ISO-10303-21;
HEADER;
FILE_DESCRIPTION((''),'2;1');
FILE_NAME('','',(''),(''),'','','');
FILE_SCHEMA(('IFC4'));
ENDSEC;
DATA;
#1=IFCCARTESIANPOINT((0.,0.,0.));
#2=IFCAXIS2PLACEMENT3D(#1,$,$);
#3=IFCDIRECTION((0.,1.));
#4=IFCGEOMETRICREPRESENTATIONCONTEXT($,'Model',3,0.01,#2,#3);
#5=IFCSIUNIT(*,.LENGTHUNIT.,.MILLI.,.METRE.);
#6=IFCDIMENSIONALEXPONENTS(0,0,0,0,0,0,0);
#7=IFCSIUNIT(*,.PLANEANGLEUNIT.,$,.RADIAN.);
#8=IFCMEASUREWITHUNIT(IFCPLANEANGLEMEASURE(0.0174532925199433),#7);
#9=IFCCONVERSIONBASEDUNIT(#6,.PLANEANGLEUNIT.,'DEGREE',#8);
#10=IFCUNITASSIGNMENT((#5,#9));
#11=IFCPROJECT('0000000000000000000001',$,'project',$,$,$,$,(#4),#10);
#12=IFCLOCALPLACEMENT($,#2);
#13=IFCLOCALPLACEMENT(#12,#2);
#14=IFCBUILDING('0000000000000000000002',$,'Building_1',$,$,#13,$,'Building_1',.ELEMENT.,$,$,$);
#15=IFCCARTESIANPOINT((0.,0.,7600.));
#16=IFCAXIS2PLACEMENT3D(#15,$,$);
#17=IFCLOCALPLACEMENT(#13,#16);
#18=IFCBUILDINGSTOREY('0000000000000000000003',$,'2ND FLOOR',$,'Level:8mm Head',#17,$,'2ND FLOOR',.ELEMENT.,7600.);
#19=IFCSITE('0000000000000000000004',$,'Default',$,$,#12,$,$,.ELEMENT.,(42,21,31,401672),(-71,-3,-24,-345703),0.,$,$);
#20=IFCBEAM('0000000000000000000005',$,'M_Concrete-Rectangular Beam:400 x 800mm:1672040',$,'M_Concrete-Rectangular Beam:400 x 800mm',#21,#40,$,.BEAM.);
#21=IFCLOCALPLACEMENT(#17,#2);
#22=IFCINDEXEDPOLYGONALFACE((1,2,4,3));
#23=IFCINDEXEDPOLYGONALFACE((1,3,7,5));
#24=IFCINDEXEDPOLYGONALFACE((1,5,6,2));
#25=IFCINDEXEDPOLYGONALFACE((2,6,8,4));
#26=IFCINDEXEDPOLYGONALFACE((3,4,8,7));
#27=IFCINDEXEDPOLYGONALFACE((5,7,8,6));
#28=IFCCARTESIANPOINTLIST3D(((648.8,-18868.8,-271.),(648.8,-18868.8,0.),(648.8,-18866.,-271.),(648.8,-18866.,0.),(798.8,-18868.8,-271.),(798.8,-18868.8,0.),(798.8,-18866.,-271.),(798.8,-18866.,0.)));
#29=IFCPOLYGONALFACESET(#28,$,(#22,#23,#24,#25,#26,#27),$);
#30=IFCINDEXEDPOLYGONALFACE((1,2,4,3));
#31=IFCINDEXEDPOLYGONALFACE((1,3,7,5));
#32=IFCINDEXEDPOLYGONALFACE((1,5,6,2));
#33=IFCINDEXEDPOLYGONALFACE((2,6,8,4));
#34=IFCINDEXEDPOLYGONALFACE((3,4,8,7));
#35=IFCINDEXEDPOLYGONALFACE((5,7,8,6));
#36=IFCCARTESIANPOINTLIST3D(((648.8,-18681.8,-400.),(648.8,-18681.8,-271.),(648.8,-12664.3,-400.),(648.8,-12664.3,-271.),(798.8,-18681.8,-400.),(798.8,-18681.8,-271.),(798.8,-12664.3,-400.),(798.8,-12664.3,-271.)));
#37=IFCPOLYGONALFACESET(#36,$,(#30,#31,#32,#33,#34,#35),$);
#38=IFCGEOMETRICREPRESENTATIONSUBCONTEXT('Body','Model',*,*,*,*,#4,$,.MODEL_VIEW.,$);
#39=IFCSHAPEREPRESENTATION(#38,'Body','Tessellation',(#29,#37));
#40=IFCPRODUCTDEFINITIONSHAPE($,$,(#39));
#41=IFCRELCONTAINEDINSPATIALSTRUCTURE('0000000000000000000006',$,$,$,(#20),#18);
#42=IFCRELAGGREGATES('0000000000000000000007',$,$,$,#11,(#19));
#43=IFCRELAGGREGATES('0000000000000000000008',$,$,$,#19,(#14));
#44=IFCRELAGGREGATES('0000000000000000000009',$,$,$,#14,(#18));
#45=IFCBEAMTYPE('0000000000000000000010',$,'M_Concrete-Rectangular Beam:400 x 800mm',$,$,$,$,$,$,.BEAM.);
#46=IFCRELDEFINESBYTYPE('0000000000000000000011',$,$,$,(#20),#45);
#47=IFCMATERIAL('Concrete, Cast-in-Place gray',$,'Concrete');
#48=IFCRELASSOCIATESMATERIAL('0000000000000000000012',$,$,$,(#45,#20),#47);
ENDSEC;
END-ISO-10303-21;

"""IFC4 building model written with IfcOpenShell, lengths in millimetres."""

from ifc_helpers import new_model, entity, si_unit, converted_unit, direction, frame, origin, place, context, subcontext, project, spatial, indexed_curve, outline, extrude, source, transform, mapped, material, type_object, type_shapes, element, save


model = new_model("IFC4")

# Units and contexts
model_context = context("Model", 3, precision=0.01, world=origin(), true_north=direction((0.0, 1.0)))
body_context = subcontext(model_context, "Body", "Model", "MODEL_VIEW")
ifc_project = project(units=[si_unit("LENGTHUNIT", "METRE", prefix="MILLI"), converted_unit("PLANEANGLEUNIT", "DEGREE", entity("IfcPlaneAngleMeasure", 0.0174532925199433), si_unit("PLANEANGLEUNIT", "RADIAN"), dimensions=[0, 0, 0, 0, 0, 0, 0])], contexts=[model_context])

# Site, building, storey
site_placement = place(None, origin())
site = spatial("IfcSite", under=ifc_project, at=site_placement, Name="Default", CompositionType="ELEMENT", RefLatitude=(42, 21, 31, 401672), RefLongitude=(-71, -3, -24, -345703), RefElevation=0.0)
building_placement = place(site_placement, origin())
building = spatial("IfcBuilding", under=site, at=building_placement, Name="Building_1", LongName="Building_1", CompositionType="ELEMENT")
storey_placement = place(building_placement, frame((0.0, 0.0, 7600.0)))
storey = spatial("IfcBuildingStorey", under=building, at=storey_placement, Name="2ND FLOOR", ObjectType="Level:8mm Head", LongName="2ND FLOOR", CompositionType="ELEMENT", Elevation=7600.0)

# Shared definitions
ifc_material_1 = material(Name="Concrete, Cast-in-Place gray", Category="Concrete")

# Beam
beam_type_1 = type_object("IfcBeamType", Name="M_Concrete-Rectangular Beam:400 x 800mm", PredefinedType="BEAM", material=ifc_material_1)
shared_shape_1 = source(origin(), body_context, "Body", "SweptSolid", [
    extrude(outline(indexed_curve([(-75.0, -135.5), (75.0, -135.5), (75.0, 135.5), (-75.0, 135.5), (-75.0, -135.5)], self_intersect=False)), frame((723.8, -18866.0, 7464.5), z_axis=(0.0, -1.0, 0.0), x_axis=(-1.0, 0.0, 0.0)), (0.0, 0.0, 1.0), 2.8),
    extrude(outline(indexed_curve([(-75.0, -64.5), (75.0, -64.5), (75.0, 64.5), (-75.0, 64.5), (-75.0, -64.5)], self_intersect=False)), frame((723.8, -12664.3, 7264.5), z_axis=(0.0, -1.0, 0.0), x_axis=(-1.0, 0.0, 0.0)), (0.0, 0.0, 1.0), 6017.5),
])
type_shapes(beam_type_1, [shared_shape_1])
beam_1_placement = place(storey_placement, frame((0.0, 0.0, -7600.0)))
element("IfcBeam", 1, at=beam_1_placement, inside=storey, type_object=beam_type_1, material=ifc_material_1, Name="M_Concrete-Rectangular Beam:400 x 800mm:1672040", ObjectType="M_Concrete-Rectangular Beam:400 x 800mm", PredefinedType="BEAM", context=body_context, shape_type="MappedRepresentation", body=[
    mapped(shared_shape_1, transform((0.0, 0.0, 0.0), scale=1.0)),
])

save(model, "model.ifc")
